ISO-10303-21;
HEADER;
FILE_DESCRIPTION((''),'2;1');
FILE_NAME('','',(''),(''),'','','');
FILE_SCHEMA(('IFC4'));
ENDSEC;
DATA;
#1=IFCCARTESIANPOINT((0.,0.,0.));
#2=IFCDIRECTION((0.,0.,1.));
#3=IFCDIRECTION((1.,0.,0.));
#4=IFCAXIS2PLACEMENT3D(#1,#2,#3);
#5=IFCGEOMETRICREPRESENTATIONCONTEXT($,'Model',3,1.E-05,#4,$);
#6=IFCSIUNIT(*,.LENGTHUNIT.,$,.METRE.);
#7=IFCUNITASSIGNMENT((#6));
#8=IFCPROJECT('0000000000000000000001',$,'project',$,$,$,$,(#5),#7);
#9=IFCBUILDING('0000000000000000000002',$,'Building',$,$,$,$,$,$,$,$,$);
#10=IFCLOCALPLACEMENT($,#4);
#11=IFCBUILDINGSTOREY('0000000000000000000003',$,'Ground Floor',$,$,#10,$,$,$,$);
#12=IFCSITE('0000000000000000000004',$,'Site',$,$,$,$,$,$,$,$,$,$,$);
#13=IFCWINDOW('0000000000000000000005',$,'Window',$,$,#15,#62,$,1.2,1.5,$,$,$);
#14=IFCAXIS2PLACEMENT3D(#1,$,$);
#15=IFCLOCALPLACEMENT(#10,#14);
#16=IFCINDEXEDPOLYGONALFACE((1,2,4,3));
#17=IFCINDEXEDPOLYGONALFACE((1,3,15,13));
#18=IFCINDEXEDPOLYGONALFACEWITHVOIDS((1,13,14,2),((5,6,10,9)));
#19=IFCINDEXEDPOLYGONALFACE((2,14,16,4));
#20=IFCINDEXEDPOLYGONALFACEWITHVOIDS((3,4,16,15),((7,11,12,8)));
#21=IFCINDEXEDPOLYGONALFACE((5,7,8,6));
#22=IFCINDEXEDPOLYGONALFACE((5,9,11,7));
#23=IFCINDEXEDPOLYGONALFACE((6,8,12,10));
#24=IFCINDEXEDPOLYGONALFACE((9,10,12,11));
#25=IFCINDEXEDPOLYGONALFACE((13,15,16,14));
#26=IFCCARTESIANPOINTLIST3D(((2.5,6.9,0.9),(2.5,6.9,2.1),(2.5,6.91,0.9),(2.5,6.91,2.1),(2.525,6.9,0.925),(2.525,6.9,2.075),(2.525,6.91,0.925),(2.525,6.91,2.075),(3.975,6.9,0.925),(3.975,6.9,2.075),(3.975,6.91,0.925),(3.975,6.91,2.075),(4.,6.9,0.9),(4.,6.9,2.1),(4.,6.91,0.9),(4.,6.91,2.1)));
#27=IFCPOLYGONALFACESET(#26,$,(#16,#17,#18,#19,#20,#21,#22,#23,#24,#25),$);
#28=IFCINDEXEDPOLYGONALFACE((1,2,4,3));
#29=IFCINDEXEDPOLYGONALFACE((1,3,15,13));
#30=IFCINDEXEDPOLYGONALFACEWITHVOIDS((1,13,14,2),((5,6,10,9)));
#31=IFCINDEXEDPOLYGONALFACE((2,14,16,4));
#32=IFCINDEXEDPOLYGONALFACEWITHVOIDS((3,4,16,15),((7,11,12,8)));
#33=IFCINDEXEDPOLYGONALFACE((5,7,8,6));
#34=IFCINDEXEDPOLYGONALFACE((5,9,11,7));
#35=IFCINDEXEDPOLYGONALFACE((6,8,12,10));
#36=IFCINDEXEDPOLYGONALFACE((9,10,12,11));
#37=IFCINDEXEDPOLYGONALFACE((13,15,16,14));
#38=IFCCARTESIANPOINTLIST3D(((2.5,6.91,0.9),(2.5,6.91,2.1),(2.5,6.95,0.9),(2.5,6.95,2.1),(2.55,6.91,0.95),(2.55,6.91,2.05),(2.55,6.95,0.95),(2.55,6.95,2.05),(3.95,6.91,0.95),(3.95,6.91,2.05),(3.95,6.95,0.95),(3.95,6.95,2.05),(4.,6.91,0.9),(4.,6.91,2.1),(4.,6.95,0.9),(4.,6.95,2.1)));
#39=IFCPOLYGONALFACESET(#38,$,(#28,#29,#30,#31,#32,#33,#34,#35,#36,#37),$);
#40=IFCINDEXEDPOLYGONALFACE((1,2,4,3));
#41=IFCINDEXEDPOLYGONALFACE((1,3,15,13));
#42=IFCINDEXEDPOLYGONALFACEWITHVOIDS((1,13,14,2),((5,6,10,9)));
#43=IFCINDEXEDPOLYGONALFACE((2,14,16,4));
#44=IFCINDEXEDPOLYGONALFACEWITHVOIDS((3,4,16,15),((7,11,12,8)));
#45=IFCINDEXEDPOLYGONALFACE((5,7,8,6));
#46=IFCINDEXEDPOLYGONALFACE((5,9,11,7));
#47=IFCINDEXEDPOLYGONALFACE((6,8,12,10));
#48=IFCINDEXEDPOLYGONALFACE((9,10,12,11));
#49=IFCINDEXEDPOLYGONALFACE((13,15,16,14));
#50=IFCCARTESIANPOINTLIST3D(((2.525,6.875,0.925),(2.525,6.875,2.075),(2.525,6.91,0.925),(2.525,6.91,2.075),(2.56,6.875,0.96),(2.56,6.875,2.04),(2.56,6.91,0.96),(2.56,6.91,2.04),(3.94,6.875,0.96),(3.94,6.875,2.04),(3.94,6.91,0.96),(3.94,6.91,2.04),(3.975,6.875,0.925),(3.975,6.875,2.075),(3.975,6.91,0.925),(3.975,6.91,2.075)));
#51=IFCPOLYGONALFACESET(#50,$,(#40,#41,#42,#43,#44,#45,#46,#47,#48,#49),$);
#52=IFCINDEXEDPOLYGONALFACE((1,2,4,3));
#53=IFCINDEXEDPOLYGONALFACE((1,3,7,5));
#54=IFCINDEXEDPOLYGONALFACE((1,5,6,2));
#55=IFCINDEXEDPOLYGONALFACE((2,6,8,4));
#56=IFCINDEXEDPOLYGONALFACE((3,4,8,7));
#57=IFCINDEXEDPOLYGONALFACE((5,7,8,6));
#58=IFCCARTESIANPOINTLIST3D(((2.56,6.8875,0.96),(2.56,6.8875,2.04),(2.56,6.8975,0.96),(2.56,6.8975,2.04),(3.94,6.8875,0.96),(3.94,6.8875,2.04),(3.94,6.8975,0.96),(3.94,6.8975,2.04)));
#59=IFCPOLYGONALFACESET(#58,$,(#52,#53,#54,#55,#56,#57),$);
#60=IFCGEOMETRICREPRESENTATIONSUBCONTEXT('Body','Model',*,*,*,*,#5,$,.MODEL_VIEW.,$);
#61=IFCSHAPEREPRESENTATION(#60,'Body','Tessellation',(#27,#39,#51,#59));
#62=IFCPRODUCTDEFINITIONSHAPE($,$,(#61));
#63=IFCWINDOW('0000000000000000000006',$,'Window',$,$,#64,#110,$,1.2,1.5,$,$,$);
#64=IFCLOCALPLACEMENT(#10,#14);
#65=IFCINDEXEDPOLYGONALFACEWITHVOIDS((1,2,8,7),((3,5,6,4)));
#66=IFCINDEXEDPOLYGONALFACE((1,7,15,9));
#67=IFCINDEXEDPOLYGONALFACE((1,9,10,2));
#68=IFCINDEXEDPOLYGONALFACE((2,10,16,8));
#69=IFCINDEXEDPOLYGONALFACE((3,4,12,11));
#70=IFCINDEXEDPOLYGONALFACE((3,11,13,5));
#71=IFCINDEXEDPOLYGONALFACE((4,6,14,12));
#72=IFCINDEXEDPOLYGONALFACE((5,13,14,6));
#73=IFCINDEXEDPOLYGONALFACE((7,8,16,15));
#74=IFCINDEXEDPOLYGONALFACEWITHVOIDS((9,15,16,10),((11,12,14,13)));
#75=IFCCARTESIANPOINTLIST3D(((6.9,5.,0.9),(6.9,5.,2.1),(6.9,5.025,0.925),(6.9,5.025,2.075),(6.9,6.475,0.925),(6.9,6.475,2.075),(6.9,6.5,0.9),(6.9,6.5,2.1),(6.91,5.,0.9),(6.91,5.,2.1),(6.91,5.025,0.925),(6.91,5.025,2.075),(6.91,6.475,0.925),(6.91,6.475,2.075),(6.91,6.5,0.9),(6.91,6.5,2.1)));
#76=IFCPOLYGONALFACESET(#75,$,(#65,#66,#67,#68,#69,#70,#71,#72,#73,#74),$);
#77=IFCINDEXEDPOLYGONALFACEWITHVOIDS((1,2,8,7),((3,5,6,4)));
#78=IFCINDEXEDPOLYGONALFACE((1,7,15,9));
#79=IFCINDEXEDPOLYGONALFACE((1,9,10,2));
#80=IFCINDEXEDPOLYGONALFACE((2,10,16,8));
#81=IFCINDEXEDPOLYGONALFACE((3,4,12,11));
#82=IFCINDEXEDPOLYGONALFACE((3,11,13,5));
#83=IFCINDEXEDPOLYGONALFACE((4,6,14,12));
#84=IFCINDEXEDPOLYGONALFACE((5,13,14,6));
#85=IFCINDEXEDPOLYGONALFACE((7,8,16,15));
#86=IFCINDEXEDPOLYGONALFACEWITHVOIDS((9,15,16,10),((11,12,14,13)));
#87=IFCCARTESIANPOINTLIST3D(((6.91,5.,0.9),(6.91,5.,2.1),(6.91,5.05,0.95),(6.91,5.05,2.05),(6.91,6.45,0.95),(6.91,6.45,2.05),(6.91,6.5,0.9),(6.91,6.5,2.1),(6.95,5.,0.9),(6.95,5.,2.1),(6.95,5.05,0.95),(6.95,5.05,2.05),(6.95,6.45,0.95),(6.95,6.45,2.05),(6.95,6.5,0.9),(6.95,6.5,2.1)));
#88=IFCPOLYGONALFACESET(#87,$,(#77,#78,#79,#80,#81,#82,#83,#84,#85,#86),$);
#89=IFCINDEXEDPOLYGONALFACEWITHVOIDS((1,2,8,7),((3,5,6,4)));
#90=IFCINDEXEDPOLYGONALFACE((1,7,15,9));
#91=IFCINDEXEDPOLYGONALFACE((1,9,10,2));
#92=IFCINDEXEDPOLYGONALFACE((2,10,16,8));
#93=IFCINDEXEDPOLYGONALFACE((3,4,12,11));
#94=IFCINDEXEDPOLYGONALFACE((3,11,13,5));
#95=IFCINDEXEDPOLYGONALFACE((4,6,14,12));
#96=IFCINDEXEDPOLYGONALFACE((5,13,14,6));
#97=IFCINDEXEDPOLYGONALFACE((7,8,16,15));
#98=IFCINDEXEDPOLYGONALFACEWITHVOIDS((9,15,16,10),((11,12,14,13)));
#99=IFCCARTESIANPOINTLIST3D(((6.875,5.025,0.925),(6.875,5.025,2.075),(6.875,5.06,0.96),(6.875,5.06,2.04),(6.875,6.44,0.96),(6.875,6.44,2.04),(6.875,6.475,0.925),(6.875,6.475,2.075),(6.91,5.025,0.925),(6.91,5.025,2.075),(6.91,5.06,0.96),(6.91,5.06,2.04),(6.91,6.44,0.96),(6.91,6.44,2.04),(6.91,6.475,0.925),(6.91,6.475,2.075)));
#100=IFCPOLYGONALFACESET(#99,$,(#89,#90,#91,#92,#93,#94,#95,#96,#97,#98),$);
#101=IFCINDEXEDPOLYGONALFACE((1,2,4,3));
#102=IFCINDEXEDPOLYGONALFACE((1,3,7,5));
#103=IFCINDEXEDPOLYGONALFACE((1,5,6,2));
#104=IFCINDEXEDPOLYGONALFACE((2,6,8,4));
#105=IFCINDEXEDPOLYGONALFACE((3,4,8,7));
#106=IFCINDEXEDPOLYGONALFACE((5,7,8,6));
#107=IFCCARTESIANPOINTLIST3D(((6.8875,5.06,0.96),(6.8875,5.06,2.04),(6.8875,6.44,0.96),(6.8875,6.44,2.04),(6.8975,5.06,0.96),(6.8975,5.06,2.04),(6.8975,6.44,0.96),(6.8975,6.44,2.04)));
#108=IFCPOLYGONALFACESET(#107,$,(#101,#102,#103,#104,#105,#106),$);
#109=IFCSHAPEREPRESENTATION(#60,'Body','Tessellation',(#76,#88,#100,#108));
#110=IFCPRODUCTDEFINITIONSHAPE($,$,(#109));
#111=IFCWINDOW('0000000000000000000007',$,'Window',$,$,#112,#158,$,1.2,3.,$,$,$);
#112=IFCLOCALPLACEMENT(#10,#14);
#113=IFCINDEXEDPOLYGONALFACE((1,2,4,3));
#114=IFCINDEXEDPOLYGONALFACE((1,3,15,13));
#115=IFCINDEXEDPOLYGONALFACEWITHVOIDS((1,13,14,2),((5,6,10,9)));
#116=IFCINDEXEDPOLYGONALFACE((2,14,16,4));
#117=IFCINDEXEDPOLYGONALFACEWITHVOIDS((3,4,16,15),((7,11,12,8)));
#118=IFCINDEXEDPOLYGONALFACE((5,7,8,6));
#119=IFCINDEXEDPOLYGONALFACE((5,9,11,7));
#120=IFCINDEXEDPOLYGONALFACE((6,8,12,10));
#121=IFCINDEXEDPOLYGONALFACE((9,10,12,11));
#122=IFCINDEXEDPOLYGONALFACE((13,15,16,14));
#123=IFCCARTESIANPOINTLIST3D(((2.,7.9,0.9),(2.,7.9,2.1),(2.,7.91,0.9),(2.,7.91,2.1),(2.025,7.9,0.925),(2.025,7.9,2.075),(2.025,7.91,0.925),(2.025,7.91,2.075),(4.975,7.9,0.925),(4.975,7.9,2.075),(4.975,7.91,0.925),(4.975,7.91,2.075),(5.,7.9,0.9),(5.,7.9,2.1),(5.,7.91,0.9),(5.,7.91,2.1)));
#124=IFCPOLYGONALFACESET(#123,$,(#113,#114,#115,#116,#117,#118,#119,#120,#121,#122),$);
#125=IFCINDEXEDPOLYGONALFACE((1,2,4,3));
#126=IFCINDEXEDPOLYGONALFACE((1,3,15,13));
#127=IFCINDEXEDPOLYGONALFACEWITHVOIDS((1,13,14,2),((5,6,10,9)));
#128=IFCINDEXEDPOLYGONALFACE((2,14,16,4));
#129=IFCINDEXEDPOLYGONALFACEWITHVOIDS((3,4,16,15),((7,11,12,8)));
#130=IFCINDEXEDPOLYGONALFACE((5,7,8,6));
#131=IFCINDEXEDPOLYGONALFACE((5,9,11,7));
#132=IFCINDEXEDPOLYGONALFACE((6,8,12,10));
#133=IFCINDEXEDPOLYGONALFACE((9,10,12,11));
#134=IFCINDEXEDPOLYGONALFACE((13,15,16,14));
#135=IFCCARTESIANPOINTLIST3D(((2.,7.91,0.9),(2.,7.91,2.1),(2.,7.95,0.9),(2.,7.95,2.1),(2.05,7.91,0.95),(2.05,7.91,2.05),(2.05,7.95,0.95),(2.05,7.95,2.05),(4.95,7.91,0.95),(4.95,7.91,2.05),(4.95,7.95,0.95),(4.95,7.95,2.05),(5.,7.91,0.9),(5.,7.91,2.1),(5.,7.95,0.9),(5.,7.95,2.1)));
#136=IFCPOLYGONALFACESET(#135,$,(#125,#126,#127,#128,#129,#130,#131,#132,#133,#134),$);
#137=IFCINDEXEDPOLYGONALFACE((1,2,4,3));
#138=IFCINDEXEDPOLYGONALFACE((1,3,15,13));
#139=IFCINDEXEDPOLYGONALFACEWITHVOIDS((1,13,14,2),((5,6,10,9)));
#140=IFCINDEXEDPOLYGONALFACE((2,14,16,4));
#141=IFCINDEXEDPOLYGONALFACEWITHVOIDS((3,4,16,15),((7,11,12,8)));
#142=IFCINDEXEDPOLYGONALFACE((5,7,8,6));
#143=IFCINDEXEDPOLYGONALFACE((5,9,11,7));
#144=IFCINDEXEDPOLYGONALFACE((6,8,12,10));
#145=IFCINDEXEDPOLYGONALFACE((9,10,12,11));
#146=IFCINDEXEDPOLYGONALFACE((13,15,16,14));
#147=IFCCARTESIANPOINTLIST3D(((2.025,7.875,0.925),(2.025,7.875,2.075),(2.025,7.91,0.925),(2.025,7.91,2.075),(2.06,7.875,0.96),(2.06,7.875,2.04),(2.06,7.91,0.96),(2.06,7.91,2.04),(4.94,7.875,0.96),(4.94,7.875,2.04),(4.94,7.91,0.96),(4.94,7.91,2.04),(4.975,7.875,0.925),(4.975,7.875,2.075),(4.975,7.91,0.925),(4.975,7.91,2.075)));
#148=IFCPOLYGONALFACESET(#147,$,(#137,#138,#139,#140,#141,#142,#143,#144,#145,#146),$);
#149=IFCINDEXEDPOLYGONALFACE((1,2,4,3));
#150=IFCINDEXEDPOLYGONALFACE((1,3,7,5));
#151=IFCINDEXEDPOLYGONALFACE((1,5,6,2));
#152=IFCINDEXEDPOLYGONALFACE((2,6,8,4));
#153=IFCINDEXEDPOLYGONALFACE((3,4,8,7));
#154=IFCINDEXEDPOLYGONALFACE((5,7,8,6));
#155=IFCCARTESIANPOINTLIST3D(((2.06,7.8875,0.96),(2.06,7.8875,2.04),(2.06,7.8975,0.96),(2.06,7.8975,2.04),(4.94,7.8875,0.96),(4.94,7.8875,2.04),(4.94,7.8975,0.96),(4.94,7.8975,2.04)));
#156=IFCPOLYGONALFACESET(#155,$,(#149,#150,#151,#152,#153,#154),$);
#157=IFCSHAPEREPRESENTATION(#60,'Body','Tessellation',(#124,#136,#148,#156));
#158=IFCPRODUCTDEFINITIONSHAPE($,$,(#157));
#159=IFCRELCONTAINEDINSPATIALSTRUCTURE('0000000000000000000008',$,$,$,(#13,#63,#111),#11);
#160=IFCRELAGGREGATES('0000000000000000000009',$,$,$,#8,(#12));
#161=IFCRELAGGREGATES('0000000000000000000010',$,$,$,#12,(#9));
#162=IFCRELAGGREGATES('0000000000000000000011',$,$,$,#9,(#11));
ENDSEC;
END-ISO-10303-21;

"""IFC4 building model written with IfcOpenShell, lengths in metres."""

from ifc_helpers import new_model, si_unit, frame, origin_with_axes, place, context, subcontext, project, spatial, line, indexed_curve, outline, extrude, element, save


model = new_model("IFC4")

# Units and contexts
model_context = context("Model", 3, precision=1e-05, world=origin_with_axes())
body_context = subcontext(model_context, "Body", "Model", "MODEL_VIEW")
ifc_project = project(units=[si_unit("LENGTHUNIT", "METRE")], contexts=[model_context])

# Site, building, storey
site = spatial("IfcSite", under=ifc_project, Name="Site")
building = spatial("IfcBuilding", under=site, Name="Building")
storey_placement = place(None, origin_with_axes())
storey = spatial("IfcBuildingStorey", under=building, at=storey_placement, Name="Ground Floor")

# Windows
for number, where, z_axis, x_axis, name in (
    (1, (4.0, 7.0, 0.9), (0.0, 0.0, 1.0), (-1.0, 0.0, 0.0), "Window"),
    (2, (7.0, 5.0, 0.9), (0.0, 0.0, 1.0), (0.0, 1.0, 0.0), "Window"),
):
    element("IfcWindow", number, at=place(storey_placement, frame(where, z_axis=z_axis, x_axis=x_axis)), inside=storey, Name=name, OverallHeight=1.2, OverallWidth=1.5, context=body_context, shape_type="SweptSolid", body=[
        extrude(outline(indexed_curve([(0.0, 0.0), (1.5, 0.0), (1.5, 1.2), (0.0, 1.2)], segments=[line(1, 2, 3, 4, 1)]), holes=[indexed_curve([(0.025, 0.025), (1.475, 0.025), (1.475, 1.175), (0.025, 1.175)], segments=[line(1, 2, 3, 4, 1)])]), frame((0.0, 0.09, 0.0), z_axis=(0.0, -1.0, 0.0), x_axis=(1.0, 0.0, 0.0)), (0.0, 0.0, -1.0), 0.01),
        extrude(outline(indexed_curve([(0.0, 0.0), (1.5, 0.0), (1.5, 1.2), (0.0, 1.2)], segments=[line(1, 2, 3, 4, 1)]), holes=[indexed_curve([(0.05, 0.05), (1.45, 0.05), (1.45, 1.15), (0.05, 1.15)], segments=[line(1, 2, 3, 4, 1)])]), frame((0.0, 0.05, 0.0), z_axis=(0.0, -1.0, 0.0), x_axis=(1.0, 0.0, 0.0)), (0.0, 0.0, -1.0), 0.04),
        extrude(outline(indexed_curve([(0.0, 0.0), (1.45, 0.0), (1.45, 1.15), (0.0, 1.15)], segments=[line(1, 2, 3, 4, 1)]), holes=[indexed_curve([(0.035, 0.035), (1.415, 0.035), (1.415, 1.115), (0.035, 1.115)], segments=[line(1, 2, 3, 4, 1)])]), frame((0.025, 0.09, 0.025), z_axis=(0.0, -1.0, 0.0), x_axis=(1.0, 0.0, 0.0)), (0.0, 0.0, -1.0), 0.035),
        extrude(outline(indexed_curve([(0.035, 0.035), (1.415, 0.035), (1.415, 1.115), (0.035, 1.115)], segments=[line(1, 2, 3, 4, 1)])), frame((0.025, 0.1025, 0.025), z_axis=(0.0, -1.0, 0.0), x_axis=(1.0, 0.0, 0.0)), (0.0, 0.0, -1.0), 0.01),
    ])
window_placement = place(storey_placement, frame((5.0, 8.0, 0.9), z_axis=(0.0, 0.0, 1.0), x_axis=(-1.0, 0.0, 0.0)))
element("IfcWindow", 3, at=window_placement, inside=storey, Name="Window", OverallHeight=1.2, OverallWidth=3.0, context=body_context, shape_type="SweptSolid", body=[
    extrude(outline(indexed_curve([(0.0, 0.0), (3.0, 0.0), (3.0, 1.2), (0.0, 1.2)], segments=[line(1, 2, 3, 4, 1)]), holes=[indexed_curve([(0.025, 0.025), (2.975, 0.025), (2.975, 1.175), (0.025, 1.175)], segments=[line(1, 2, 3, 4, 1)])]), frame((0.0, 0.09, 0.0), z_axis=(0.0, -1.0, 0.0), x_axis=(1.0, 0.0, 0.0)), (0.0, 0.0, -1.0), 0.01),
    extrude(outline(indexed_curve([(0.0, 0.0), (3.0, 0.0), (3.0, 1.2), (0.0, 1.2)], segments=[line(1, 2, 3, 4, 1)]), holes=[indexed_curve([(0.05, 0.05), (2.95, 0.05), (2.95, 1.15), (0.05, 1.15)], segments=[line(1, 2, 3, 4, 1)])]), frame((0.0, 0.05, 0.0), z_axis=(0.0, -1.0, 0.0), x_axis=(1.0, 0.0, 0.0)), (0.0, 0.0, -1.0), 0.04),
    extrude(outline(indexed_curve([(0.0, 0.0), (2.95, 0.0), (2.95, 1.15), (0.0, 1.15)], segments=[line(1, 2, 3, 4, 1)]), holes=[indexed_curve([(0.035, 0.035), (2.915, 0.035), (2.915, 1.115), (0.035, 1.115)], segments=[line(1, 2, 3, 4, 1)])]), frame((0.025, 0.09, 0.025), z_axis=(0.0, -1.0, 0.0), x_axis=(1.0, 0.0, 0.0)), (0.0, 0.0, -1.0), 0.035),
    extrude(outline(indexed_curve([(0.035, 0.035), (2.915, 0.035), (2.915, 1.115), (0.035, 1.115)], segments=[line(1, 2, 3, 4, 1)])), frame((0.025, 0.1025, 0.025), z_axis=(0.0, -1.0, 0.0), x_axis=(1.0, 0.0, 0.0)), (0.0, 0.0, -1.0), 0.01),
])

save(model, "model.ifc")
